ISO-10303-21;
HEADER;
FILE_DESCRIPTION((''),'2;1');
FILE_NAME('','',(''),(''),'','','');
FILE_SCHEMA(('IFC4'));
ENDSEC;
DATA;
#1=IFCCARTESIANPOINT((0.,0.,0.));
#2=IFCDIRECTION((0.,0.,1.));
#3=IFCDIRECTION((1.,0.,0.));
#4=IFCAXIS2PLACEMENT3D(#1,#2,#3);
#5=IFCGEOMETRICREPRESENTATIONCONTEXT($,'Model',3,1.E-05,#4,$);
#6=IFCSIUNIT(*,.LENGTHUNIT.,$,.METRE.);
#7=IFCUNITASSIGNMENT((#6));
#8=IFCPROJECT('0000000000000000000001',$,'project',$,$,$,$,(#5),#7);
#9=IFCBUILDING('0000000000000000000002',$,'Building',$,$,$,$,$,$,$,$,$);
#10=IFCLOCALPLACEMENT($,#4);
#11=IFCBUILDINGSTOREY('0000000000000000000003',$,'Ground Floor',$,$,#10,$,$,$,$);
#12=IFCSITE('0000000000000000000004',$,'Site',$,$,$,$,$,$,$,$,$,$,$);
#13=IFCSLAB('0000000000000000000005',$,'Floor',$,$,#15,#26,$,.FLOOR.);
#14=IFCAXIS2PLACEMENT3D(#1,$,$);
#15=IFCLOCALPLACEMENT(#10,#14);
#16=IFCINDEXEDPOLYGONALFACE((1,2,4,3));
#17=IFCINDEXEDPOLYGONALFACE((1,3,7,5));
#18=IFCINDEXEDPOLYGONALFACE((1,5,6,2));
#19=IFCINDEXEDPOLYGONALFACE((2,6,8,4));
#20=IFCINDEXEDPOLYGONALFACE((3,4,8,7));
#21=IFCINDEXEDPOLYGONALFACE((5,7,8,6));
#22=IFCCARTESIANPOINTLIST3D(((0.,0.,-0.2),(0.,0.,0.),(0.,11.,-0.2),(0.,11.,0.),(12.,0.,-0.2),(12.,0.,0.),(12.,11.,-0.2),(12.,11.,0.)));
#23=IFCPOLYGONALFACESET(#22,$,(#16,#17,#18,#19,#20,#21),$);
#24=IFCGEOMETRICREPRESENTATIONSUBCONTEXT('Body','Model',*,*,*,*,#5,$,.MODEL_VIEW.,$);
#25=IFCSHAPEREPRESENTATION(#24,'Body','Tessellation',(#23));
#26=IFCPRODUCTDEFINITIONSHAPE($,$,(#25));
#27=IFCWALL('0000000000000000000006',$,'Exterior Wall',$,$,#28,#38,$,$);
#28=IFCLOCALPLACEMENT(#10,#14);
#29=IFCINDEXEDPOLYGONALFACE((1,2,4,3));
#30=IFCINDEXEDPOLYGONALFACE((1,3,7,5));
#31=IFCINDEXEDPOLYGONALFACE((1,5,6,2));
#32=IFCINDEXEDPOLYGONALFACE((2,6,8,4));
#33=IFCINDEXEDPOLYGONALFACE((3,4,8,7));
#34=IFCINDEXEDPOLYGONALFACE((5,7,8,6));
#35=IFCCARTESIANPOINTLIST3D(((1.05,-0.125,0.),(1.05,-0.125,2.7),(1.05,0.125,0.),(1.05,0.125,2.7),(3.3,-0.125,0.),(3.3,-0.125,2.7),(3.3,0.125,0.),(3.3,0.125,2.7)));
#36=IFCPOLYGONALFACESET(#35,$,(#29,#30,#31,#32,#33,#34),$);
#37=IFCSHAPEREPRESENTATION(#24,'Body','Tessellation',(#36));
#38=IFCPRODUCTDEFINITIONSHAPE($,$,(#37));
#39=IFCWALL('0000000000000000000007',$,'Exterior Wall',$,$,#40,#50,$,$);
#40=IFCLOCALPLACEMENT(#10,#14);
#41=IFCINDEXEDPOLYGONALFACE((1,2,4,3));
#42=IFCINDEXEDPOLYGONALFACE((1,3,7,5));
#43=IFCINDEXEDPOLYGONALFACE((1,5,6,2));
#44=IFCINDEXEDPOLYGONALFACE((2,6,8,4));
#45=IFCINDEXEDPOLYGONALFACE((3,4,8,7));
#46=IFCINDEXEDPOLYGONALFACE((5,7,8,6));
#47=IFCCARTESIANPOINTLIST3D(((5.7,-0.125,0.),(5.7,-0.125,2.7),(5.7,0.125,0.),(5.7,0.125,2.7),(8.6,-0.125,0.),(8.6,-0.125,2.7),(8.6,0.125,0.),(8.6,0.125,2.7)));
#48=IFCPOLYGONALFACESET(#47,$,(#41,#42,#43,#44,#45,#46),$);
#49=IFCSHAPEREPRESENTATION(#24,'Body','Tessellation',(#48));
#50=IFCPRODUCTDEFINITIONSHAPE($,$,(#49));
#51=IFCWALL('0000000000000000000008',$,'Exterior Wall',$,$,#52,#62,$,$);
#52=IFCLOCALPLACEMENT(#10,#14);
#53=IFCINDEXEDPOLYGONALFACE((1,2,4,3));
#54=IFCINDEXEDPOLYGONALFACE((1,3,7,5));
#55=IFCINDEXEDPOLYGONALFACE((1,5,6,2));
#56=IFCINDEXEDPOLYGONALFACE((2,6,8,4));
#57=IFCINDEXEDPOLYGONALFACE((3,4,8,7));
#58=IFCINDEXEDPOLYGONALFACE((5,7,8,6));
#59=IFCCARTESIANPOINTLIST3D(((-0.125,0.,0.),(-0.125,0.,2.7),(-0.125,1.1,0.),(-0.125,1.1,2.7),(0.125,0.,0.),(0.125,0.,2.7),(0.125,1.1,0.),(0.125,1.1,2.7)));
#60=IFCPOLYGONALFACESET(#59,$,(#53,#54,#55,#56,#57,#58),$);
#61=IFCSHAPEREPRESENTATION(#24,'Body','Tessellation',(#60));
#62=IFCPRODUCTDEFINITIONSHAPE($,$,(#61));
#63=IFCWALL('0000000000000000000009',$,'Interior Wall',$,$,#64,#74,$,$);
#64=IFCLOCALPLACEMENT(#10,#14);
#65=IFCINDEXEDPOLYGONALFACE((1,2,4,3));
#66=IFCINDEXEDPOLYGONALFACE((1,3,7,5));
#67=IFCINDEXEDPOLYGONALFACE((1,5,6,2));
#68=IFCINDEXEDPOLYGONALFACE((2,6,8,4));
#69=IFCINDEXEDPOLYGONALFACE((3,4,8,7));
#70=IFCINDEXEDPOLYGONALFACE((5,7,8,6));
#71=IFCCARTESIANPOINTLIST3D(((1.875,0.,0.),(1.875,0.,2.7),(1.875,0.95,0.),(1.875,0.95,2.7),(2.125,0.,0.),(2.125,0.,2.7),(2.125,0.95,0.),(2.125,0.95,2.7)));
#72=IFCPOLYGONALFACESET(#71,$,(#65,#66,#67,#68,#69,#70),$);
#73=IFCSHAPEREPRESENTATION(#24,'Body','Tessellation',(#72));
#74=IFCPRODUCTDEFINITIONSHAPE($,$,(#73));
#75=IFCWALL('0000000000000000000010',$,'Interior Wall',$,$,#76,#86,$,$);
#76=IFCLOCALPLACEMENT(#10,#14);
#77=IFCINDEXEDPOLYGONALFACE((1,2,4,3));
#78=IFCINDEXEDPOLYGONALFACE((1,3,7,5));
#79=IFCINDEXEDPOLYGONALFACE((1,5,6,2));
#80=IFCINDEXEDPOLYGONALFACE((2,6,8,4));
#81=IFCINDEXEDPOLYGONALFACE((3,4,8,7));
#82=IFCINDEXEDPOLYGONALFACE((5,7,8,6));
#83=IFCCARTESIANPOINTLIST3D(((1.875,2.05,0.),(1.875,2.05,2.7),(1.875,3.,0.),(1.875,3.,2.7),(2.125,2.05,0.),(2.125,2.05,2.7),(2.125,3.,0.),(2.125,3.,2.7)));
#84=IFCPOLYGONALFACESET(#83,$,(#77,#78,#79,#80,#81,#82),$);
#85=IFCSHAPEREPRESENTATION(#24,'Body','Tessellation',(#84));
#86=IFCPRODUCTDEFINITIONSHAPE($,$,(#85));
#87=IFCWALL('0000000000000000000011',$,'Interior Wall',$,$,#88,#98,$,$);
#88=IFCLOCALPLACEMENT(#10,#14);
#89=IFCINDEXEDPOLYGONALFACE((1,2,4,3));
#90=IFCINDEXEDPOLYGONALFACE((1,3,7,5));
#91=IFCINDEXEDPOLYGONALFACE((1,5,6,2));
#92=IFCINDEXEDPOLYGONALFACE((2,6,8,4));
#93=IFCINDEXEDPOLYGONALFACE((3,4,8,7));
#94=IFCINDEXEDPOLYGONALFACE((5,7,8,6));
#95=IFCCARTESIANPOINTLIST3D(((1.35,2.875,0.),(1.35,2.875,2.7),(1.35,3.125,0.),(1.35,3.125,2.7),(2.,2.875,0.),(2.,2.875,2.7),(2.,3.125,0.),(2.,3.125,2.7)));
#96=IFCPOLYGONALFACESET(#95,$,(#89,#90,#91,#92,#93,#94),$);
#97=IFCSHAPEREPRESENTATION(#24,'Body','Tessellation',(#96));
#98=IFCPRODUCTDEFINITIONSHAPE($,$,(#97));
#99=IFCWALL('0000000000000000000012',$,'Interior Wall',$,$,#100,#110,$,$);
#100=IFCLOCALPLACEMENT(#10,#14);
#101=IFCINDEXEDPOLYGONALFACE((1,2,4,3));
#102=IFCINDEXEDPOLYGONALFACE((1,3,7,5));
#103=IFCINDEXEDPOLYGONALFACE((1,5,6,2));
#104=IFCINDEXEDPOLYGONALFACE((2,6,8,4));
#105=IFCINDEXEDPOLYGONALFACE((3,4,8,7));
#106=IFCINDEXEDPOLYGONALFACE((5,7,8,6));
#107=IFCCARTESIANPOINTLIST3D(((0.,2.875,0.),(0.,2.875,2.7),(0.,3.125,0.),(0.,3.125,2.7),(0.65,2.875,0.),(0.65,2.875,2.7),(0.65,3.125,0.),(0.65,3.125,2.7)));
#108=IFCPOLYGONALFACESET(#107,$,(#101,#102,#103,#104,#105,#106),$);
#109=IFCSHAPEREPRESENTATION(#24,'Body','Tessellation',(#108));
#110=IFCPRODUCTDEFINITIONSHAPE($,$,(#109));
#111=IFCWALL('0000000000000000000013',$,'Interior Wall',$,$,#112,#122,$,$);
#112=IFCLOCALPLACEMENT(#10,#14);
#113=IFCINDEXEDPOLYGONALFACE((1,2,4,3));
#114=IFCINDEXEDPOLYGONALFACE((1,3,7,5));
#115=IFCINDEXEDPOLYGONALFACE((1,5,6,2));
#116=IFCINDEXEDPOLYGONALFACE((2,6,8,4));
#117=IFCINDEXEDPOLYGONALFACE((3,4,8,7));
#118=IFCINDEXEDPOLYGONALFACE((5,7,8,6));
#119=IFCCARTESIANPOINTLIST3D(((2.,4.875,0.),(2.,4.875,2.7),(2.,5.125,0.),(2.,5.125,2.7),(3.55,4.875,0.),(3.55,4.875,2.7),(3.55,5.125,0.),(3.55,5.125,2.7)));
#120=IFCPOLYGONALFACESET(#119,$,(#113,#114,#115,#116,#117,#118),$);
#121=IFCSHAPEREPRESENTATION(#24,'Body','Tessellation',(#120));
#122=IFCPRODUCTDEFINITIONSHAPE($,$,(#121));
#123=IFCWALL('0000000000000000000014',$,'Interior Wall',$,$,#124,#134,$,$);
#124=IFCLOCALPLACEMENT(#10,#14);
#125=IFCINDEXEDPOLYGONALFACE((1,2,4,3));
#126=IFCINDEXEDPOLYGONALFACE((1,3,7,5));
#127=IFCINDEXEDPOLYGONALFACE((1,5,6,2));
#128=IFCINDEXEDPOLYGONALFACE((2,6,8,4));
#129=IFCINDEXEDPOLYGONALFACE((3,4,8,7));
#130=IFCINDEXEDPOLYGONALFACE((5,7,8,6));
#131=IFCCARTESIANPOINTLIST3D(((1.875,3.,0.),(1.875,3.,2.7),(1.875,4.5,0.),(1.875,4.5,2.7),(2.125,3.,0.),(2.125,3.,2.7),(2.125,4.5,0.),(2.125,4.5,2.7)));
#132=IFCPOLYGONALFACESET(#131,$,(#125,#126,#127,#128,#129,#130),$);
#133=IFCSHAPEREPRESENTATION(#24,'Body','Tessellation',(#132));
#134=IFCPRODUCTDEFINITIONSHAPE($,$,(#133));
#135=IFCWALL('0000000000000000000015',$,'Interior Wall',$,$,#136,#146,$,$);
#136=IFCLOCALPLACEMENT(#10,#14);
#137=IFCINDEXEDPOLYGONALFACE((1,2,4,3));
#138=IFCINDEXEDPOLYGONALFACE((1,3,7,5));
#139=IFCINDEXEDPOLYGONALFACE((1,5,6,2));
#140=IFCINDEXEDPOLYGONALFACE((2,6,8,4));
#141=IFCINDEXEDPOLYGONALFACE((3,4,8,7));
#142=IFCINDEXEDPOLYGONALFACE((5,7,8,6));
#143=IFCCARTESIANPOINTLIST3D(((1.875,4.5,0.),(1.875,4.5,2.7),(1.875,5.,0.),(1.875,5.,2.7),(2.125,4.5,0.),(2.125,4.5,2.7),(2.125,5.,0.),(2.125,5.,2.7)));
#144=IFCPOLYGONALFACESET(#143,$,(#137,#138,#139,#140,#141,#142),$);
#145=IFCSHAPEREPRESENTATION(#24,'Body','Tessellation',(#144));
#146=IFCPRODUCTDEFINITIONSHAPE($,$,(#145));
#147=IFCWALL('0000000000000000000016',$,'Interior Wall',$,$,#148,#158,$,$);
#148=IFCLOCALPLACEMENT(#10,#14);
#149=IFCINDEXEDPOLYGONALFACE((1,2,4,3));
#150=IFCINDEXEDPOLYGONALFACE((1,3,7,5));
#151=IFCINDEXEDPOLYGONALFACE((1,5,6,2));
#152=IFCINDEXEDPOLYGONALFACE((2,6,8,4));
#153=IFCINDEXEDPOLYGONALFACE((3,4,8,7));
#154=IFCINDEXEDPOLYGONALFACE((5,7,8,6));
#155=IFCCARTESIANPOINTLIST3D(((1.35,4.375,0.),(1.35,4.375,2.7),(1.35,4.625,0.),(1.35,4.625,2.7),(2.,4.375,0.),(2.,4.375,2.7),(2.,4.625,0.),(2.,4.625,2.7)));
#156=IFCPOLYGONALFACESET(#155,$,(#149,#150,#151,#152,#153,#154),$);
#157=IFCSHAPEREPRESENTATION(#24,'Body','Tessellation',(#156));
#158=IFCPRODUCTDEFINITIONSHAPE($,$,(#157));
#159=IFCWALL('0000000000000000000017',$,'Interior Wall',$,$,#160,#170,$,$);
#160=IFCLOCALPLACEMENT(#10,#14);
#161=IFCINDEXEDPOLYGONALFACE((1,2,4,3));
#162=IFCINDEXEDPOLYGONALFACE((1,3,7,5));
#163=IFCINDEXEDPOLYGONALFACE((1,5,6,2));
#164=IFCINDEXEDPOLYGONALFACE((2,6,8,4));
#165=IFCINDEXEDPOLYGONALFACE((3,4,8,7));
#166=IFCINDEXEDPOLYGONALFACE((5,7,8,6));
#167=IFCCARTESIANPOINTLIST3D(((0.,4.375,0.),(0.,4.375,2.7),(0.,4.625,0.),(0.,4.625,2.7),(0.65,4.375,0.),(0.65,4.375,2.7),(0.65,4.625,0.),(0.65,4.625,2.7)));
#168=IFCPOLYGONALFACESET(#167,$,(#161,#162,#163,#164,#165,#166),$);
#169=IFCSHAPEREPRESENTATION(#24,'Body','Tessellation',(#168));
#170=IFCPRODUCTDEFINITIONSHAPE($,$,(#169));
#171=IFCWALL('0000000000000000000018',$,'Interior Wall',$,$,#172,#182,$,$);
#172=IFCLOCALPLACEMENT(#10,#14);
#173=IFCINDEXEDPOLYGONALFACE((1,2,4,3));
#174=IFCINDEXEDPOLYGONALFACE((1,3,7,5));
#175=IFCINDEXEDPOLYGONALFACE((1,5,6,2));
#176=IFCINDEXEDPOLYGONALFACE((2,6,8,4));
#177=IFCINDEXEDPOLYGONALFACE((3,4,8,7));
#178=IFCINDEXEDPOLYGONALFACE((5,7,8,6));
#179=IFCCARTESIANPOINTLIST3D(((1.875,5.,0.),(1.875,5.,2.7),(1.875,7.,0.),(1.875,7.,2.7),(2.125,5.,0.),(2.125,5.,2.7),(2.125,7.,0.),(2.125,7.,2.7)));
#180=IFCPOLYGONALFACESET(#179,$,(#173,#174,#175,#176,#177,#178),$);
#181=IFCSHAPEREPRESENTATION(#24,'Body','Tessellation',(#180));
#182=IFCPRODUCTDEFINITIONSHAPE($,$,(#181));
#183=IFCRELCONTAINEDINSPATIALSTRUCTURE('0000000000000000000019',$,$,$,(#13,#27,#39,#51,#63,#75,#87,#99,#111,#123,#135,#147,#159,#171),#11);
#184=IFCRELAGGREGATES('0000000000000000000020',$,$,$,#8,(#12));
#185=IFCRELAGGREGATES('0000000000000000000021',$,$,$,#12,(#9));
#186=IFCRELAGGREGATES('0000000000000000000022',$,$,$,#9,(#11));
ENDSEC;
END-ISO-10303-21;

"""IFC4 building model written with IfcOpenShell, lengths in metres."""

from ifc_helpers import new_model, si_unit, frame, origin_with_axes, place, context, subcontext, project, spatial, indexed_curve, outline, extrude, element, save


model = new_model("IFC4")

# Units and contexts
model_context = context("Model", 3, precision=1e-05, world=origin_with_axes())
body_context = subcontext(model_context, "Body", "Model", "MODEL_VIEW")
ifc_project = project(units=[si_unit("LENGTHUNIT", "METRE")], contexts=[model_context])

# Site, building, storey
site = spatial("IfcSite", under=ifc_project, Name="Site")
building = spatial("IfcBuilding", under=site, Name="Building")
storey_placement = place(None, origin_with_axes())
storey = spatial("IfcBuildingStorey", under=building, at=storey_placement, Name="Ground Floor")

# Slab
slab_placement = place(storey_placement, frame((0.0, 0.0, -0.2), z_axis=(0.0, 0.0, 1.0), x_axis=(1.0, 0.0, 0.0)))
element("IfcSlab", 1, at=slab_placement, inside=storey, Name="Floor", PredefinedType="FLOOR", context=body_context, shape_type="SweptSolid", body=[
    extrude(outline(indexed_curve([(0.0, 0.0), (12.0, 0.0), (12.0, 11.0), (0.0, 11.0)])), None, (0.0, 0.0, 1.0), 0.2),
])

# Walls
wall_1_placement = place(storey_placement, frame((1.05, 0.0, 0.0), z_axis=(0.0, 0.0, 1.0), x_axis=(1.0, 0.0, 0.0)))
element("IfcWall", 2, at=wall_1_placement, inside=storey, Name="Exterior Wall", context=body_context, shape_type="SweptSolid", body=[
    extrude(outline(indexed_curve([(0.0, 0.0), (0.0, 0.25), (2.25, 0.25), (2.25, 0.0), (0.0, 0.0)], self_intersect=False)), frame((0.0, -0.125, 0.0), z_axis=(0.0, 0.0, 1.0), x_axis=(1.0, 0.0, 0.0)), (0.0, 0.0, 1.0), 2.7),
])
wall_2_placement = place(storey_placement, frame((5.7, 0.0, 0.0), z_axis=(0.0, 0.0, 1.0), x_axis=(1.0, 0.0, 0.0)))
element("IfcWall", 3, at=wall_2_placement, inside=storey, Name="Exterior Wall", context=body_context, shape_type="SweptSolid", body=[
    extrude(outline(indexed_curve([(0.0, 0.0), (0.0, 0.25), (2.9, 0.25), (2.9, 0.0), (0.0, 0.0)], self_intersect=False)), frame((0.0, -0.125, 0.0), z_axis=(0.0, 0.0, 1.0), x_axis=(1.0, 0.0, 0.0)), (0.0, 0.0, 1.0), 2.7),
])
wall_3_placement = place(storey_placement, frame((0.0, 1.1, 0.0), z_axis=(0.0, 0.0, 1.0), x_axis=(0.0, -1.0, 0.0)))
element("IfcWall", 4, at=wall_3_placement, inside=storey, Name="Exterior Wall", context=body_context, shape_type="SweptSolid", body=[
    extrude(outline(indexed_curve([(0.0, 0.0), (0.0, 0.25), (1.1, 0.25), (1.1, 0.0), (0.0, 0.0)], self_intersect=False)), frame((0.0, -0.125, 0.0), z_axis=(0.0, 0.0, 1.0), x_axis=(1.0, 0.0, 0.0)), (0.0, 0.0, 1.0), 2.7),
])
wall_4_placement = place(storey_placement, frame((2.0, 0.0, 0.0), z_axis=(0.0, 0.0, 1.0), x_axis=(0.0, 1.0, 0.0)))
element("IfcWall", 5, at=wall_4_placement, inside=storey, Name="Interior Wall", context=body_context, shape_type="SweptSolid", body=[
    extrude(outline(indexed_curve([(0.0, 0.0), (0.0, 0.25), (0.95, 0.25), (0.95, 0.0), (0.0, 0.0)], self_intersect=False)), frame((0.0, -0.125, 0.0), z_axis=(0.0, 0.0, 1.0), x_axis=(1.0, 0.0, 0.0)), (0.0, 0.0, 1.0), 2.7),
])
wall_5_placement = place(storey_placement, frame((2.0, 2.05, 0.0), z_axis=(0.0, 0.0, 1.0), x_axis=(0.0, 1.0, 0.0)))
element("IfcWall", 6, at=wall_5_placement, inside=storey, Name="Interior Wall", context=body_context, shape_type="SweptSolid", body=[
    extrude(outline(indexed_curve([(0.0, 0.0), (0.0, 0.25), (0.95, 0.25), (0.95, 0.0), (0.0, 0.0)], self_intersect=False)), frame((0.0, -0.125, 0.0), z_axis=(0.0, 0.0, 1.0), x_axis=(1.0, 0.0, 0.0)), (0.0, 0.0, 1.0), 2.7),
])
for number, where, z_axis, x_axis, name in (
    (7, (2.0, 3.0, 0.0), (0.0, 0.0, 1.0), (-1.0, 0.0, 0.0), "Interior Wall"),
    (8, (0.65, 3.0, 0.0), (0.0, 0.0, 1.0), (-1.0, 0.0, 0.0), "Interior Wall"),
):
    element("IfcWall", number, at=place(storey_placement, frame(where, z_axis=z_axis, x_axis=x_axis)), inside=storey, Name=name, context=body_context, shape_type="SweptSolid", body=[
        extrude(outline(indexed_curve([(0.0, 0.0), (0.0, 0.25), (0.65, 0.25), (0.65, 0.0), (0.0, 0.0)], self_intersect=False)), frame((0.0, -0.125, 0.0), z_axis=(0.0, 0.0, 1.0), x_axis=(1.0, 0.0, 0.0)), (0.0, 0.0, 1.0), 2.7),
    ])
wall_6_placement = place(storey_placement, frame((3.55, 5.0, 0.0), z_axis=(0.0, 0.0, 1.0), x_axis=(-1.0, 0.0, 0.0)))
element("IfcWall", 9, at=wall_6_placement, inside=storey, Name="Interior Wall", context=body_context, shape_type="SweptSolid", body=[
    extrude(outline(indexed_curve([(0.0, 0.0), (0.0, 0.25), (1.55, 0.25), (1.55, 0.0), (0.0, 0.0)], self_intersect=False)), frame((0.0, -0.125, 0.0), z_axis=(0.0, 0.0, 1.0), x_axis=(1.0, 0.0, 0.0)), (0.0, 0.0, 1.0), 2.7),
])
wall_7_placement = place(storey_placement, frame((2.0, 4.5, 0.0), z_axis=(0.0, 0.0, 1.0), x_axis=(0.0, -1.0, 0.0)))
element("IfcWall", 10, at=wall_7_placement, inside=storey, Name="Interior Wall", context=body_context, shape_type="SweptSolid", body=[
    extrude(outline(indexed_curve([(0.0, 0.0), (0.0, 0.25), (1.5, 0.25), (1.5, 0.0), (0.0, 0.0)], self_intersect=False)), frame((0.0, -0.125, 0.0), z_axis=(0.0, 0.0, 1.0), x_axis=(1.0, 0.0, 0.0)), (0.0, 0.0, 1.0), 2.7),
])
wall_8_placement = place(storey_placement, frame((2.0, 5.0, 0.0), z_axis=(0.0, 0.0, 1.0), x_axis=(0.0, -1.0, 0.0)))
element("IfcWall", 11, at=wall_8_placement, inside=storey, Name="Interior Wall", context=body_context, shape_type="SweptSolid", body=[
    extrude(outline(indexed_curve([(0.0, 0.0), (0.0, 0.25), (0.5, 0.25), (0.5, 0.0), (0.0, 0.0)], self_intersect=False)), frame((0.0, -0.125, 0.0), z_axis=(0.0, 0.0, 1.0), x_axis=(1.0, 0.0, 0.0)), (0.0, 0.0, 1.0), 2.7),
])
for number, where, z_axis, x_axis, name in (
    (12, (2.0, 4.5, 0.0), (0.0, 0.0, 1.0), (-1.0, 0.0, 0.0), "Interior Wall"),
    (13, (0.65, 4.5, 0.0), (0.0, 0.0, 1.0), (-1.0, 0.0, 0.0), "Interior Wall"),
):
    element("IfcWall", number, at=place(storey_placement, frame(where, z_axis=z_axis, x_axis=x_axis)), inside=storey, Name=name, context=body_context, shape_type="SweptSolid", body=[
        extrude(outline(indexed_curve([(0.0, 0.0), (0.0, 0.25), (0.65, 0.25), (0.65, 0.0), (0.0, 0.0)], self_intersect=False)), frame((0.0, -0.125, 0.0), z_axis=(0.0, 0.0, 1.0), x_axis=(1.0, 0.0, 0.0)), (0.0, 0.0, 1.0), 2.7),
    ])
wall_9_placement = place(storey_placement, frame((2.0, 5.0, 0.0), z_axis=(0.0, 0.0, 1.0), x_axis=(0.0, 1.0, 0.0)))
element("IfcWall", 14, at=wall_9_placement, inside=storey, Name="Interior Wall", context=body_context, shape_type="SweptSolid", body=[
    extrude(outline(indexed_curve([(0.0, 0.0), (0.0, 0.25), (2.0, 0.25), (2.0, 0.0), (0.0, 0.0)], self_intersect=False)), frame((0.0, -0.125, 0.0), z_axis=(0.0, 0.0, 1.0), x_axis=(1.0, 0.0, 0.0)), (0.0, 0.0, 1.0), 2.7),
])

save(model, "model.ifc")
